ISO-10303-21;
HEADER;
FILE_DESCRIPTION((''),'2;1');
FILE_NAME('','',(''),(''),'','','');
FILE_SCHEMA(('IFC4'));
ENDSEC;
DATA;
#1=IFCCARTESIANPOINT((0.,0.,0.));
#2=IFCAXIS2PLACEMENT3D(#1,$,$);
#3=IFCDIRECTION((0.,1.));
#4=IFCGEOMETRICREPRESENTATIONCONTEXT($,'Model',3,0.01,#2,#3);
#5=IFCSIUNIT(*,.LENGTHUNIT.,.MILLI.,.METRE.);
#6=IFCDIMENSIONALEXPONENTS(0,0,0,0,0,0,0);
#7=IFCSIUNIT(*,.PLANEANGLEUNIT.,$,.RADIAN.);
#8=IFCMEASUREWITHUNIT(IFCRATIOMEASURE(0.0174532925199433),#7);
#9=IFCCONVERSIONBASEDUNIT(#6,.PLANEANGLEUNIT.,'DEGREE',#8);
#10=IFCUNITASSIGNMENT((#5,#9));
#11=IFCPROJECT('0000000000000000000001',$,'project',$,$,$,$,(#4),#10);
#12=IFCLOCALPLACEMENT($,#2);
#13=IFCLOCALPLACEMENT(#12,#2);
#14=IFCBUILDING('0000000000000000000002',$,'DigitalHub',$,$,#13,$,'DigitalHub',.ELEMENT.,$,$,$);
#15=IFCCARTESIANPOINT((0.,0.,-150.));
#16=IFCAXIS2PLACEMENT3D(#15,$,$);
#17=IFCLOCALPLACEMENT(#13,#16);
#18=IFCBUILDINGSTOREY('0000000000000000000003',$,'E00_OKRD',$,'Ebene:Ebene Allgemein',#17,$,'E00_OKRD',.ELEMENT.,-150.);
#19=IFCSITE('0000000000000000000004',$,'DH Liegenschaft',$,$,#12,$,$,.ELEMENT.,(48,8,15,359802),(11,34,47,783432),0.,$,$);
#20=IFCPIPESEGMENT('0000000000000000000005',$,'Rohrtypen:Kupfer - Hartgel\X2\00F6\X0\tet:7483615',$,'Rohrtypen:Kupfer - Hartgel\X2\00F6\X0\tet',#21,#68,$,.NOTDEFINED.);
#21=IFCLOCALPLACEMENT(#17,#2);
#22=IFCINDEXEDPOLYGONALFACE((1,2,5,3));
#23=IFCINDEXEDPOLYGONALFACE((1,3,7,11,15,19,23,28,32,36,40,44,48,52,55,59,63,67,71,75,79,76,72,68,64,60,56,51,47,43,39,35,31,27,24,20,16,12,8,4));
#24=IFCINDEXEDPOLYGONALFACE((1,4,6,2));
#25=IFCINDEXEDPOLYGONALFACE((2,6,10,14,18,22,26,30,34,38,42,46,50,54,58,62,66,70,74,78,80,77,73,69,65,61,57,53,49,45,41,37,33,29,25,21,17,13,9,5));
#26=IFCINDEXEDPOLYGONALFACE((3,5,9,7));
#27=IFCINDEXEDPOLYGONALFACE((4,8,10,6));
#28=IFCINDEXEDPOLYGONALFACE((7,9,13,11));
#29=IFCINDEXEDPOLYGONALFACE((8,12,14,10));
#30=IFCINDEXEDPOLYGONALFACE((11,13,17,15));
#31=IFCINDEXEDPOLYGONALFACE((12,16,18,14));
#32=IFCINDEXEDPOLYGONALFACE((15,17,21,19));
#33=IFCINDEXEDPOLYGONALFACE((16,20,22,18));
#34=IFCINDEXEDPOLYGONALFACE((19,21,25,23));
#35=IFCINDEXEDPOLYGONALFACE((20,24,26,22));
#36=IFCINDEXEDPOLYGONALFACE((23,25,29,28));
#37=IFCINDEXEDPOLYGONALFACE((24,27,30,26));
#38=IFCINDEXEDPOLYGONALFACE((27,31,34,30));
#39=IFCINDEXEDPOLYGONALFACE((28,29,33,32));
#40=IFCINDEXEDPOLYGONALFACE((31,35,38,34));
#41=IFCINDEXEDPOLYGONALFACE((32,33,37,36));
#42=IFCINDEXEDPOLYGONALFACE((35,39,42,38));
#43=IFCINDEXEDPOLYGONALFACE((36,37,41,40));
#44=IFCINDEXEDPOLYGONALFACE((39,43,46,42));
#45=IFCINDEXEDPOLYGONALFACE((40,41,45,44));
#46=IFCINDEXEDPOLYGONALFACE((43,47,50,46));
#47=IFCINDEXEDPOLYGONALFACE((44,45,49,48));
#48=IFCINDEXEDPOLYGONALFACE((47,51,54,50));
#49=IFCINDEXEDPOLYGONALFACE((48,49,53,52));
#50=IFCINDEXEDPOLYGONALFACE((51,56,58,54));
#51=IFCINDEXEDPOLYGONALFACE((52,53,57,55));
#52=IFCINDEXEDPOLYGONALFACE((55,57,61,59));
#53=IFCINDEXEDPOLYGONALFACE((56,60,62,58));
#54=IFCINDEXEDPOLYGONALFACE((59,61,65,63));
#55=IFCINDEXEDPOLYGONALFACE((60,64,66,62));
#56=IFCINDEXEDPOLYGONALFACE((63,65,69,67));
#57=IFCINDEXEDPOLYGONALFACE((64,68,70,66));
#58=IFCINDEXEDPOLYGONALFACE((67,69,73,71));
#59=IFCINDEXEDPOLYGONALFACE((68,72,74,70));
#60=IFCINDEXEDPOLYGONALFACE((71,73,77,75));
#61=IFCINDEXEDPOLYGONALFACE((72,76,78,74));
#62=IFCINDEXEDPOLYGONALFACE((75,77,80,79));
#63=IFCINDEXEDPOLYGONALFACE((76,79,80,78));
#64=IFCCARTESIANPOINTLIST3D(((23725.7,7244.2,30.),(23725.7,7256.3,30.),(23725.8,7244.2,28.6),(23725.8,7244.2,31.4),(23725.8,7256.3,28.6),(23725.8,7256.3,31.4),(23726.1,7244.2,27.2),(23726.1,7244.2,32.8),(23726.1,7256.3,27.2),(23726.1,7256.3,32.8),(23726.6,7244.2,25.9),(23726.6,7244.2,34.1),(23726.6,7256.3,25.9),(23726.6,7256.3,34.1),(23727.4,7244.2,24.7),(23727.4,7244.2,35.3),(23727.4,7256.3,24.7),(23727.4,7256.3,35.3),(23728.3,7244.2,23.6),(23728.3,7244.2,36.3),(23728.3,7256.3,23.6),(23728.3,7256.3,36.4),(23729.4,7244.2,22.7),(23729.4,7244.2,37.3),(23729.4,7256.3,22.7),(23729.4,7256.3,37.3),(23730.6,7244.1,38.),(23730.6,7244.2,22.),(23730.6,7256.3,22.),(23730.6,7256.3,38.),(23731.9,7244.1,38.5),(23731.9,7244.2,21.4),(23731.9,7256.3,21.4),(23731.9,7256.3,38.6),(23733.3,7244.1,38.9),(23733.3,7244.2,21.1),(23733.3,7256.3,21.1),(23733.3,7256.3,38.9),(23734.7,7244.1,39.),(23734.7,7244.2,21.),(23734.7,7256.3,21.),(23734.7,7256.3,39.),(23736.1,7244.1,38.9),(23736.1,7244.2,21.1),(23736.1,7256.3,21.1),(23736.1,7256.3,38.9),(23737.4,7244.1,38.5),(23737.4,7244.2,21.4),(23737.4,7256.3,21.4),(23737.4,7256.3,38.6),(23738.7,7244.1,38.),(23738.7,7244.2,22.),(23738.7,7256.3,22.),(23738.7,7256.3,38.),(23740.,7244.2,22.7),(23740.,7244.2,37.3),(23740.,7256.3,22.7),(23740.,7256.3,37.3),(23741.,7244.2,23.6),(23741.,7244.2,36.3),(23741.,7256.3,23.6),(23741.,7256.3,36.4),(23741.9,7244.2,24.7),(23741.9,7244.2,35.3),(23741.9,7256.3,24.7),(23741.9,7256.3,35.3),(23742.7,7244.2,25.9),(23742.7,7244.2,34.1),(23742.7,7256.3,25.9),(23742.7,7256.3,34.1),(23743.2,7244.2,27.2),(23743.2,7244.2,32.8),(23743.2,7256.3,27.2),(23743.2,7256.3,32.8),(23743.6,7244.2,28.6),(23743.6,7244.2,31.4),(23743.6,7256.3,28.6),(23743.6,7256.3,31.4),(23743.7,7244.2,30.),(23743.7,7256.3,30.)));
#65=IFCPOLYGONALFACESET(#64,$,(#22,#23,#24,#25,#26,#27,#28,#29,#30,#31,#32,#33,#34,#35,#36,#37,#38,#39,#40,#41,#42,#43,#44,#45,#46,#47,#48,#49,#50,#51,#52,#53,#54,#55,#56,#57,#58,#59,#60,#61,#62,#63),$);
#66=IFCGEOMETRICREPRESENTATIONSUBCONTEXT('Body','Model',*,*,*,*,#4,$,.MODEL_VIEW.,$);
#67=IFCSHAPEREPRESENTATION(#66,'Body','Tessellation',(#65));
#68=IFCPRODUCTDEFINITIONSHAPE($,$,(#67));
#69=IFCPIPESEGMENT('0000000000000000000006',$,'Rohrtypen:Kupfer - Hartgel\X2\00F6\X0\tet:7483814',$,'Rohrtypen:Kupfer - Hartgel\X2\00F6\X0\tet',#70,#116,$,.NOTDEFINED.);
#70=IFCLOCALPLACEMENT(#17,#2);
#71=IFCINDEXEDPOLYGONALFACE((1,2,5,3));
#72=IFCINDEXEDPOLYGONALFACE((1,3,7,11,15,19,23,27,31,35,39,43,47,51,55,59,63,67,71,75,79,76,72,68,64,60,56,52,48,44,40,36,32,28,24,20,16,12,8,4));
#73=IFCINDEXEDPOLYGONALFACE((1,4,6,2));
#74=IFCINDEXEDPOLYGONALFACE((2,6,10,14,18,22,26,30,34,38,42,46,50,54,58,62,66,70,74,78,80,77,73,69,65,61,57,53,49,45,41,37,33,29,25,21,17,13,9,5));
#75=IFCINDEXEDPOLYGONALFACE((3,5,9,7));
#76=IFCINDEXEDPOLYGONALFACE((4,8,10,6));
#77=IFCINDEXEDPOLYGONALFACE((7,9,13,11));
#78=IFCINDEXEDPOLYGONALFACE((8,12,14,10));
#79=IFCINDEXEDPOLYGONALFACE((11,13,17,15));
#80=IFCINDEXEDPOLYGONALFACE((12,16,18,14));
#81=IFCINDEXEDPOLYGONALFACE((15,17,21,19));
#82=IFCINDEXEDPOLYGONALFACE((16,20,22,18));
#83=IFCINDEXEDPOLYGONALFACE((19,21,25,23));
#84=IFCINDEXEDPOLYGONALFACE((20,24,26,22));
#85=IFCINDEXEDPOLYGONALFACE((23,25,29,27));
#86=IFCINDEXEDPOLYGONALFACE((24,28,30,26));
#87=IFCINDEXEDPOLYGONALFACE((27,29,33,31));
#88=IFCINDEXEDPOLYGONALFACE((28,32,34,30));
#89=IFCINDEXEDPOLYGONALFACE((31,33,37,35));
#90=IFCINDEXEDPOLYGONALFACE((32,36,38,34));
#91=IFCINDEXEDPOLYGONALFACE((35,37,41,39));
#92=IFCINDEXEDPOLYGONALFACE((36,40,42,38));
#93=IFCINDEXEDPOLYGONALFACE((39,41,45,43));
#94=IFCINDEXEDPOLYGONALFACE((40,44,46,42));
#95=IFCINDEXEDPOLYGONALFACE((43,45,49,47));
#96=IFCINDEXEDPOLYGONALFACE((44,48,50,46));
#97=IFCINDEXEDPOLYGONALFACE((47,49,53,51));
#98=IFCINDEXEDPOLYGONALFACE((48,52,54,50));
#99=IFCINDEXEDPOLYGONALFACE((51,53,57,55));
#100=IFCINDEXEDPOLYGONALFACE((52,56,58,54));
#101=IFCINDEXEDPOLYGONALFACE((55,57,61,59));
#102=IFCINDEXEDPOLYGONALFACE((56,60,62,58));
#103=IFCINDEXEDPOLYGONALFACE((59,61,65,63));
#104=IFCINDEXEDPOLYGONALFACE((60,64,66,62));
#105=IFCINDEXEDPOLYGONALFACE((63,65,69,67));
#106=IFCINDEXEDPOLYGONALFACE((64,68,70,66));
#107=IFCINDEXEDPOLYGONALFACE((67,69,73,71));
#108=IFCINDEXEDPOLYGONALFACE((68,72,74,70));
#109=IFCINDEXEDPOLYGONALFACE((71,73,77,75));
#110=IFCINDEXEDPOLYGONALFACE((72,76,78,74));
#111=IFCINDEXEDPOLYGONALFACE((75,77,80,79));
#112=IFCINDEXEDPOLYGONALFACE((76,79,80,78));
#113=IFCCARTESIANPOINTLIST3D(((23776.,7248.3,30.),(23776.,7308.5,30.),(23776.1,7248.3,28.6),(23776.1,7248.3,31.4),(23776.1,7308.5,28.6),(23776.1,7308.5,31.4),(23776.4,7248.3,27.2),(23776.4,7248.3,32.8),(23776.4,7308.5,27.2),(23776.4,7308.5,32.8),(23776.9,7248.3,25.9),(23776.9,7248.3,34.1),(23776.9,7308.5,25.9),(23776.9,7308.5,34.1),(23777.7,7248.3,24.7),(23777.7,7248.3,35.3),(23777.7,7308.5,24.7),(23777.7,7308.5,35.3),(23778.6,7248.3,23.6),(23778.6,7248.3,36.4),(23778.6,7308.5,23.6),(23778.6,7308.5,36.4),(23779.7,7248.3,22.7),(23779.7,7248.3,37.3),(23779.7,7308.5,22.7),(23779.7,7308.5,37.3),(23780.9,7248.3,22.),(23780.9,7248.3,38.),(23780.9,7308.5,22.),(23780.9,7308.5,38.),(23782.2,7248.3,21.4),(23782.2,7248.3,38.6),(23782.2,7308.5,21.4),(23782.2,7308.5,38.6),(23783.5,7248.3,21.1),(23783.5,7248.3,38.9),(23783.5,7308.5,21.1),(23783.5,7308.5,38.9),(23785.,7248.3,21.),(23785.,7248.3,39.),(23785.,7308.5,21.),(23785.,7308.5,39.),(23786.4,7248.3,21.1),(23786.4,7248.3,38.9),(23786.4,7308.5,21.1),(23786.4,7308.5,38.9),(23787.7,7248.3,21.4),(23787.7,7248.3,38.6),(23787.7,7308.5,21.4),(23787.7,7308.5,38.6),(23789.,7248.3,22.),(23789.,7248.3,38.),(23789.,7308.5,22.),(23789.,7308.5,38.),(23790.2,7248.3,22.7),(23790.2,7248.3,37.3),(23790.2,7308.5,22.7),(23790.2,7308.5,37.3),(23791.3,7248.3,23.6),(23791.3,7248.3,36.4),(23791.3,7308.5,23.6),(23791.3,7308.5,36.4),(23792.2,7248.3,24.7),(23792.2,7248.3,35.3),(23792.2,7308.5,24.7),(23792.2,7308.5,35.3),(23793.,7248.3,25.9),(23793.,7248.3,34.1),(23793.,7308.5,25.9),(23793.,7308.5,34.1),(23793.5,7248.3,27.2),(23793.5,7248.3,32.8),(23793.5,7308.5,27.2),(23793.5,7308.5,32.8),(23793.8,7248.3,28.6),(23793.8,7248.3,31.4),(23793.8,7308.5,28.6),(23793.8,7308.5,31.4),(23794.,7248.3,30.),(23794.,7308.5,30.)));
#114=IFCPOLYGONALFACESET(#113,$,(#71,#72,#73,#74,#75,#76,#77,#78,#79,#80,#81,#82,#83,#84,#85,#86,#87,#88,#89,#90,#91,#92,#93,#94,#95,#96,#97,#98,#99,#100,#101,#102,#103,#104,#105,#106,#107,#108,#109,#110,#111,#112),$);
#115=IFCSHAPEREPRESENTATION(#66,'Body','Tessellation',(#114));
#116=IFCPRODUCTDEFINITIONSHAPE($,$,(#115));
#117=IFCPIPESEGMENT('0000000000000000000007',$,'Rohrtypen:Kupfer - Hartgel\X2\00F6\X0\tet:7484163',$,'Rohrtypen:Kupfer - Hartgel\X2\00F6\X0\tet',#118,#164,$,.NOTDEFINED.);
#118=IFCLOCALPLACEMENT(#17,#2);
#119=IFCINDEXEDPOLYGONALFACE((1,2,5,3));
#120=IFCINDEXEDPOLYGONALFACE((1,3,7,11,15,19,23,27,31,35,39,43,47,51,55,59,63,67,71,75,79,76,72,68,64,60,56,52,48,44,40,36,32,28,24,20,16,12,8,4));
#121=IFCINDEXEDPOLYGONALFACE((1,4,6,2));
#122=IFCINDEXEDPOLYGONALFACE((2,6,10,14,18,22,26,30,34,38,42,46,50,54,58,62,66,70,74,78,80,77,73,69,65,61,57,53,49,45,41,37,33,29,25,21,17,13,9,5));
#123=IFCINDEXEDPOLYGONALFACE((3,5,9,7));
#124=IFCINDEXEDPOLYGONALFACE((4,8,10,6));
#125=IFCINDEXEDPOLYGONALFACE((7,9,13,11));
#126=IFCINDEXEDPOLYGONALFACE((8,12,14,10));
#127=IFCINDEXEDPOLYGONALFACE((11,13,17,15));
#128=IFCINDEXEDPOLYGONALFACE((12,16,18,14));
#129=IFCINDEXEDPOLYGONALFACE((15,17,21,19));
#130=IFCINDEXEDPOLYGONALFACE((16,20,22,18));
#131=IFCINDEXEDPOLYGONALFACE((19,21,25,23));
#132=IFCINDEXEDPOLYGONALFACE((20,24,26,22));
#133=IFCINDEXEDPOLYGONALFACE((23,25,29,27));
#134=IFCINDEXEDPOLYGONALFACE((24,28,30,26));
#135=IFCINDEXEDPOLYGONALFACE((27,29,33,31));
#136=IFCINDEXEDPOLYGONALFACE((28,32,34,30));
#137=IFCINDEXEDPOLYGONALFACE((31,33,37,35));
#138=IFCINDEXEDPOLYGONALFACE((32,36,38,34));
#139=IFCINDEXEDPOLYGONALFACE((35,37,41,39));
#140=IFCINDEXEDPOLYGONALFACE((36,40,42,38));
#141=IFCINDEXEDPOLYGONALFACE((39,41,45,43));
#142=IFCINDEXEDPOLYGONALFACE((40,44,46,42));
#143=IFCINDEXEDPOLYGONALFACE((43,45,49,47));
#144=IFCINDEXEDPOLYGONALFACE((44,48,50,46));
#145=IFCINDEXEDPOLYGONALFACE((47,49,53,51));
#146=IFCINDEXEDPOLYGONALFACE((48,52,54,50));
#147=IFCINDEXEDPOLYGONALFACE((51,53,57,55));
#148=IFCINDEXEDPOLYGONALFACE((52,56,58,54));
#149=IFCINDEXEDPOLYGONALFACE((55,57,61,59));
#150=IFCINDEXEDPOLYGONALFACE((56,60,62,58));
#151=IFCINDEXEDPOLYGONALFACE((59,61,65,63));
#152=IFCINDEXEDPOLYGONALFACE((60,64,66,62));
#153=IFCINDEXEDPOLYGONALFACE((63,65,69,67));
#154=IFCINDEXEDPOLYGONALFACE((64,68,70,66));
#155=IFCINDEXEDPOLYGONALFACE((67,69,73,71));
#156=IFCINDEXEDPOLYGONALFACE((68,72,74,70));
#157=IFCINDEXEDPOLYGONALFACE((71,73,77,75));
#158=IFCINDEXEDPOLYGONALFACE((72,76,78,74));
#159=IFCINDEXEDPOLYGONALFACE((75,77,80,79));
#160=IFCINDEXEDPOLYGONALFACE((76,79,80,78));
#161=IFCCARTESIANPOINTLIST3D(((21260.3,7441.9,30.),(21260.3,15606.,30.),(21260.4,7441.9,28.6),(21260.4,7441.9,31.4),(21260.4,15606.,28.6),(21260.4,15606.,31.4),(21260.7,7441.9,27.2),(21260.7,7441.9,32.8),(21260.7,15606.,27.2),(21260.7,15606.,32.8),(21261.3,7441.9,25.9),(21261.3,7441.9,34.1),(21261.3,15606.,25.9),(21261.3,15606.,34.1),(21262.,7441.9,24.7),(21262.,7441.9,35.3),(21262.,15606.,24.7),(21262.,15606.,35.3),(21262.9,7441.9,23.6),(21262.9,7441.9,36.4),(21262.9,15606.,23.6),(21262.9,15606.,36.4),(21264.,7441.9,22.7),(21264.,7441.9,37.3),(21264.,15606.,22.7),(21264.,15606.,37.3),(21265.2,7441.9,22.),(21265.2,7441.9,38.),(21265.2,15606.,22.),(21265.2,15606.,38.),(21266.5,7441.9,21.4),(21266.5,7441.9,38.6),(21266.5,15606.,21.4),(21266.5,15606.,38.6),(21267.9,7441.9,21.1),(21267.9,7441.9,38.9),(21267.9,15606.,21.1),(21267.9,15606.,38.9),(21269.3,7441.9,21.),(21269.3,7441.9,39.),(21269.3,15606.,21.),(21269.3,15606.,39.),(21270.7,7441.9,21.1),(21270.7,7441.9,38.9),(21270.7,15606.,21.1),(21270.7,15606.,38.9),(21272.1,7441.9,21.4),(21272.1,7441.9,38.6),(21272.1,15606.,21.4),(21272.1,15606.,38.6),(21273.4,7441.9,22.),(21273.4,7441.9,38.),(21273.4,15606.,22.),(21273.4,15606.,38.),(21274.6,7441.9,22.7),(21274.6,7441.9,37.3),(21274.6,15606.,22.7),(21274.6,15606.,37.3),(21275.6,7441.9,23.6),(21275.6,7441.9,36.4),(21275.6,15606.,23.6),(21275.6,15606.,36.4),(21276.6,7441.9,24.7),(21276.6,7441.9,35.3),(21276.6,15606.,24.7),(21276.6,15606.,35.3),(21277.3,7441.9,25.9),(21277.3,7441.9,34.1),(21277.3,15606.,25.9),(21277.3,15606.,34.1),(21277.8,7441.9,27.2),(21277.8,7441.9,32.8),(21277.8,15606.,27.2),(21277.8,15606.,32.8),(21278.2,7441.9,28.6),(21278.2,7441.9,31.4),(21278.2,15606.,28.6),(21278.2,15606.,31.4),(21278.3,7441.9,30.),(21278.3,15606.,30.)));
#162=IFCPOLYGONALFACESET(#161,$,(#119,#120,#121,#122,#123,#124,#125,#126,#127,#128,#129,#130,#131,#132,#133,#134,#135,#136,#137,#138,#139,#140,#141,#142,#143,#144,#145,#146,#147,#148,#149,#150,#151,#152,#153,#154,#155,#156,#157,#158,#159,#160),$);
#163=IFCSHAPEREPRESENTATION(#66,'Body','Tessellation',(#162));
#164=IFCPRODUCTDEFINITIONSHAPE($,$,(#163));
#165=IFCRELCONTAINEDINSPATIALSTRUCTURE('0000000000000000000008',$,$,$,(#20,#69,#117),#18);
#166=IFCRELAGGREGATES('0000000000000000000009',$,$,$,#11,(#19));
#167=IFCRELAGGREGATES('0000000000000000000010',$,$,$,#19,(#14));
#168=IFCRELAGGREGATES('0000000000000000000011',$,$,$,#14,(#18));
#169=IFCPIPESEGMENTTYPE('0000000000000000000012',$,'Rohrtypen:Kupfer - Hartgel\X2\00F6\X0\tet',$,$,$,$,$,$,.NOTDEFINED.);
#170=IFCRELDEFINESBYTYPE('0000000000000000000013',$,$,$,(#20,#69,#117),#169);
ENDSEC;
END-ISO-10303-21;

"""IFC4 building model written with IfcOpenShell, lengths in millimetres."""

from ifc_helpers import new_model, entity, si_unit, converted_unit, direction, frame, origin, place, context, subcontext, project, spatial, indexed_curve, outline, extrude, type_object, element, save


model = new_model("IFC4")

# Units and contexts
model_context = context("Model", 3, precision=0.01, world=origin(), true_north=direction((0.0, 1.0)))
body_context = subcontext(model_context, "Body", "Model", "MODEL_VIEW")
ifc_project = project(units=[si_unit("LENGTHUNIT", "METRE", prefix="MILLI"), converted_unit("PLANEANGLEUNIT", "DEGREE", entity("IfcRatioMeasure", 0.0174532925199433), si_unit("PLANEANGLEUNIT", "RADIAN"), dimensions=[0, 0, 0, 0, 0, 0, 0])], contexts=[model_context])

# Site, building, storey
site_placement = place(None, origin())
site = spatial("IfcSite", under=ifc_project, at=site_placement, Name="DH Liegenschaft", CompositionType="ELEMENT", RefLatitude=(48, 8, 15, 359802), RefLongitude=(11, 34, 47, 783432), RefElevation=0.0)
building_placement = place(site_placement, origin())
building = spatial("IfcBuilding", under=site, at=building_placement, Name="DigitalHub", LongName="DigitalHub", CompositionType="ELEMENT")
storey_placement = place(building_placement, frame((0.0, 0.0, -150.0)))
storey = spatial("IfcBuildingStorey", under=building, at=storey_placement, Name="E00_OKRD", ObjectType="Ebene:Ebene Allgemein", LongName="E00_OKRD", CompositionType="ELEMENT", Elevation=-150.0)

# Pipe segments
pipe_segment_type = type_object("IfcPipeSegmentType", Name="Rohrtypen:Kupfer - Hartgelötet", PredefinedType="NOTDEFINED")
pipe_segment_1_placement = place(storey_placement, frame((23724.1, 7244.1, 19.4)))
element("IfcPipeSegment", 1, at=pipe_segment_1_placement, inside=storey, type_object=pipe_segment_type, Name="Rohrtypen:Kupfer - Hartgelötet:7483615", ObjectType="Rohrtypen:Kupfer - Hartgelötet", PredefinedType="NOTDEFINED", context=body_context, shape_type="SweptSolid", body=[
    extrude(outline(indexed_curve([(9.0, 0.0), (8.9, 1.4), (8.6, 2.8), (8.0, 4.1), (7.3, 5.3), (6.4, 6.4), (5.3, 7.3), (4.1, 8.0), (2.8, 8.6), (1.4, 8.9), (0.0, 9.0), (-1.4, 8.9), (-2.8, 8.6), (-4.1, 8.0), (-5.3, 7.3), (-6.4, 6.4), (-7.3, 5.3), (-8.0, 4.1), (-8.6, 2.8), (-8.9, 1.4), (-9.0, 0.0), (-8.9, -1.4), (-8.6, -2.8), (-8.0, -4.1), (-7.3, -5.3), (-6.4, -6.4), (-5.3, -7.3), (-4.1, -8.0), (-2.8, -8.6), (-1.4, -8.9), (0.0, -9.0), (1.4, -8.9), (2.8, -8.6), (4.1, -8.0), (5.3, -7.3), (6.4, -6.4), (7.3, -5.3), (8.0, -4.1), (8.6, -2.8), (8.9, -1.4), (9.0, 0.0)], self_intersect=False)), frame((10.6, 0.0, 10.6), z_axis=(0.0, 1.0, 0.000964), x_axis=(1.0, 0.0, 0.0)), (0.0, 0.0, 1.0), 12.1),
])
pipe_segment_2_placement = place(storey_placement, frame((23774.4, 7248.3, 19.4)))
element("IfcPipeSegment", 2, at=pipe_segment_2_placement, inside=storey, type_object=pipe_segment_type, Name="Rohrtypen:Kupfer - Hartgelötet:7483814", ObjectType="Rohrtypen:Kupfer - Hartgelötet", PredefinedType="NOTDEFINED", context=body_context, shape_type="SweptSolid", body=[
    extrude(outline(indexed_curve([(9.0, 0.0), (8.9, 1.4), (8.6, 2.8), (8.0, 4.1), (7.3, 5.3), (6.4, 6.4), (5.3, 7.3), (4.1, 8.0), (2.8, 8.6), (1.4, 8.9), (0.0, 9.0), (-1.4, 8.9), (-2.8, 8.6), (-4.1, 8.0), (-5.3, 7.3), (-6.4, 6.4), (-7.3, 5.3), (-8.0, 4.1), (-8.6, 2.8), (-8.9, 1.4), (-9.0, 0.0), (-8.9, -1.4), (-8.6, -2.8), (-8.0, -4.1), (-7.3, -5.3), (-6.4, -6.4), (-5.3, -7.3), (-4.1, -8.0), (-2.8, -8.6), (-1.4, -8.9), (0.0, -9.0), (1.4, -8.9), (2.8, -8.6), (4.1, -8.0), (5.3, -7.3), (6.4, -6.4), (7.3, -5.3), (8.0, -4.1), (8.6, -2.8), (8.9, -1.4), (9.0, 0.0)], self_intersect=False)), frame((10.6, 0.0, 10.6), z_axis=(0.0, 1.0, 0.0), x_axis=(1.0, 0.0, 0.0)), (0.0, 0.0, 1.0), 60.2),
])
pipe_segment_3_placement = place(storey_placement, frame((21258.7, 7441.9, 19.4)))
element("IfcPipeSegment", 3, at=pipe_segment_3_placement, inside=storey, type_object=pipe_segment_type, Name="Rohrtypen:Kupfer - Hartgelötet:7484163", ObjectType="Rohrtypen:Kupfer - Hartgelötet", PredefinedType="NOTDEFINED", context=body_context, shape_type="SweptSolid", body=[
    extrude(outline(indexed_curve([(9.0, 0.0), (8.9, 1.4), (8.6, 2.8), (8.0, 4.1), (7.3, 5.3), (6.4, 6.4), (5.3, 7.3), (4.1, 8.0), (2.8, 8.6), (1.4, 8.9), (0.0, 9.0), (-1.4, 8.9), (-2.8, 8.6), (-4.1, 8.0), (-5.3, 7.3), (-6.4, 6.4), (-7.3, 5.3), (-8.0, 4.1), (-8.6, 2.8), (-8.9, 1.4), (-9.0, 0.0), (-8.9, -1.4), (-8.6, -2.8), (-8.0, -4.1), (-7.3, -5.3), (-6.4, -6.4), (-5.3, -7.3), (-4.1, -8.0), (-2.8, -8.6), (-1.4, -8.9), (0.0, -9.0), (1.4, -8.9), (2.8, -8.6), (4.1, -8.0), (5.3, -7.3), (6.4, -6.4), (7.3, -5.3), (8.0, -4.1), (8.6, -2.8), (8.9, -1.4), (9.0, 0.0)], self_intersect=False)), frame((10.6, 0.0, 10.6), z_axis=(0.0, 1.0, 0.000001), x_axis=(-1.0, 0.0, 0.0)), (0.0, 0.0, 1.0), 8164.0),
])

save(model, "model.ifc")
